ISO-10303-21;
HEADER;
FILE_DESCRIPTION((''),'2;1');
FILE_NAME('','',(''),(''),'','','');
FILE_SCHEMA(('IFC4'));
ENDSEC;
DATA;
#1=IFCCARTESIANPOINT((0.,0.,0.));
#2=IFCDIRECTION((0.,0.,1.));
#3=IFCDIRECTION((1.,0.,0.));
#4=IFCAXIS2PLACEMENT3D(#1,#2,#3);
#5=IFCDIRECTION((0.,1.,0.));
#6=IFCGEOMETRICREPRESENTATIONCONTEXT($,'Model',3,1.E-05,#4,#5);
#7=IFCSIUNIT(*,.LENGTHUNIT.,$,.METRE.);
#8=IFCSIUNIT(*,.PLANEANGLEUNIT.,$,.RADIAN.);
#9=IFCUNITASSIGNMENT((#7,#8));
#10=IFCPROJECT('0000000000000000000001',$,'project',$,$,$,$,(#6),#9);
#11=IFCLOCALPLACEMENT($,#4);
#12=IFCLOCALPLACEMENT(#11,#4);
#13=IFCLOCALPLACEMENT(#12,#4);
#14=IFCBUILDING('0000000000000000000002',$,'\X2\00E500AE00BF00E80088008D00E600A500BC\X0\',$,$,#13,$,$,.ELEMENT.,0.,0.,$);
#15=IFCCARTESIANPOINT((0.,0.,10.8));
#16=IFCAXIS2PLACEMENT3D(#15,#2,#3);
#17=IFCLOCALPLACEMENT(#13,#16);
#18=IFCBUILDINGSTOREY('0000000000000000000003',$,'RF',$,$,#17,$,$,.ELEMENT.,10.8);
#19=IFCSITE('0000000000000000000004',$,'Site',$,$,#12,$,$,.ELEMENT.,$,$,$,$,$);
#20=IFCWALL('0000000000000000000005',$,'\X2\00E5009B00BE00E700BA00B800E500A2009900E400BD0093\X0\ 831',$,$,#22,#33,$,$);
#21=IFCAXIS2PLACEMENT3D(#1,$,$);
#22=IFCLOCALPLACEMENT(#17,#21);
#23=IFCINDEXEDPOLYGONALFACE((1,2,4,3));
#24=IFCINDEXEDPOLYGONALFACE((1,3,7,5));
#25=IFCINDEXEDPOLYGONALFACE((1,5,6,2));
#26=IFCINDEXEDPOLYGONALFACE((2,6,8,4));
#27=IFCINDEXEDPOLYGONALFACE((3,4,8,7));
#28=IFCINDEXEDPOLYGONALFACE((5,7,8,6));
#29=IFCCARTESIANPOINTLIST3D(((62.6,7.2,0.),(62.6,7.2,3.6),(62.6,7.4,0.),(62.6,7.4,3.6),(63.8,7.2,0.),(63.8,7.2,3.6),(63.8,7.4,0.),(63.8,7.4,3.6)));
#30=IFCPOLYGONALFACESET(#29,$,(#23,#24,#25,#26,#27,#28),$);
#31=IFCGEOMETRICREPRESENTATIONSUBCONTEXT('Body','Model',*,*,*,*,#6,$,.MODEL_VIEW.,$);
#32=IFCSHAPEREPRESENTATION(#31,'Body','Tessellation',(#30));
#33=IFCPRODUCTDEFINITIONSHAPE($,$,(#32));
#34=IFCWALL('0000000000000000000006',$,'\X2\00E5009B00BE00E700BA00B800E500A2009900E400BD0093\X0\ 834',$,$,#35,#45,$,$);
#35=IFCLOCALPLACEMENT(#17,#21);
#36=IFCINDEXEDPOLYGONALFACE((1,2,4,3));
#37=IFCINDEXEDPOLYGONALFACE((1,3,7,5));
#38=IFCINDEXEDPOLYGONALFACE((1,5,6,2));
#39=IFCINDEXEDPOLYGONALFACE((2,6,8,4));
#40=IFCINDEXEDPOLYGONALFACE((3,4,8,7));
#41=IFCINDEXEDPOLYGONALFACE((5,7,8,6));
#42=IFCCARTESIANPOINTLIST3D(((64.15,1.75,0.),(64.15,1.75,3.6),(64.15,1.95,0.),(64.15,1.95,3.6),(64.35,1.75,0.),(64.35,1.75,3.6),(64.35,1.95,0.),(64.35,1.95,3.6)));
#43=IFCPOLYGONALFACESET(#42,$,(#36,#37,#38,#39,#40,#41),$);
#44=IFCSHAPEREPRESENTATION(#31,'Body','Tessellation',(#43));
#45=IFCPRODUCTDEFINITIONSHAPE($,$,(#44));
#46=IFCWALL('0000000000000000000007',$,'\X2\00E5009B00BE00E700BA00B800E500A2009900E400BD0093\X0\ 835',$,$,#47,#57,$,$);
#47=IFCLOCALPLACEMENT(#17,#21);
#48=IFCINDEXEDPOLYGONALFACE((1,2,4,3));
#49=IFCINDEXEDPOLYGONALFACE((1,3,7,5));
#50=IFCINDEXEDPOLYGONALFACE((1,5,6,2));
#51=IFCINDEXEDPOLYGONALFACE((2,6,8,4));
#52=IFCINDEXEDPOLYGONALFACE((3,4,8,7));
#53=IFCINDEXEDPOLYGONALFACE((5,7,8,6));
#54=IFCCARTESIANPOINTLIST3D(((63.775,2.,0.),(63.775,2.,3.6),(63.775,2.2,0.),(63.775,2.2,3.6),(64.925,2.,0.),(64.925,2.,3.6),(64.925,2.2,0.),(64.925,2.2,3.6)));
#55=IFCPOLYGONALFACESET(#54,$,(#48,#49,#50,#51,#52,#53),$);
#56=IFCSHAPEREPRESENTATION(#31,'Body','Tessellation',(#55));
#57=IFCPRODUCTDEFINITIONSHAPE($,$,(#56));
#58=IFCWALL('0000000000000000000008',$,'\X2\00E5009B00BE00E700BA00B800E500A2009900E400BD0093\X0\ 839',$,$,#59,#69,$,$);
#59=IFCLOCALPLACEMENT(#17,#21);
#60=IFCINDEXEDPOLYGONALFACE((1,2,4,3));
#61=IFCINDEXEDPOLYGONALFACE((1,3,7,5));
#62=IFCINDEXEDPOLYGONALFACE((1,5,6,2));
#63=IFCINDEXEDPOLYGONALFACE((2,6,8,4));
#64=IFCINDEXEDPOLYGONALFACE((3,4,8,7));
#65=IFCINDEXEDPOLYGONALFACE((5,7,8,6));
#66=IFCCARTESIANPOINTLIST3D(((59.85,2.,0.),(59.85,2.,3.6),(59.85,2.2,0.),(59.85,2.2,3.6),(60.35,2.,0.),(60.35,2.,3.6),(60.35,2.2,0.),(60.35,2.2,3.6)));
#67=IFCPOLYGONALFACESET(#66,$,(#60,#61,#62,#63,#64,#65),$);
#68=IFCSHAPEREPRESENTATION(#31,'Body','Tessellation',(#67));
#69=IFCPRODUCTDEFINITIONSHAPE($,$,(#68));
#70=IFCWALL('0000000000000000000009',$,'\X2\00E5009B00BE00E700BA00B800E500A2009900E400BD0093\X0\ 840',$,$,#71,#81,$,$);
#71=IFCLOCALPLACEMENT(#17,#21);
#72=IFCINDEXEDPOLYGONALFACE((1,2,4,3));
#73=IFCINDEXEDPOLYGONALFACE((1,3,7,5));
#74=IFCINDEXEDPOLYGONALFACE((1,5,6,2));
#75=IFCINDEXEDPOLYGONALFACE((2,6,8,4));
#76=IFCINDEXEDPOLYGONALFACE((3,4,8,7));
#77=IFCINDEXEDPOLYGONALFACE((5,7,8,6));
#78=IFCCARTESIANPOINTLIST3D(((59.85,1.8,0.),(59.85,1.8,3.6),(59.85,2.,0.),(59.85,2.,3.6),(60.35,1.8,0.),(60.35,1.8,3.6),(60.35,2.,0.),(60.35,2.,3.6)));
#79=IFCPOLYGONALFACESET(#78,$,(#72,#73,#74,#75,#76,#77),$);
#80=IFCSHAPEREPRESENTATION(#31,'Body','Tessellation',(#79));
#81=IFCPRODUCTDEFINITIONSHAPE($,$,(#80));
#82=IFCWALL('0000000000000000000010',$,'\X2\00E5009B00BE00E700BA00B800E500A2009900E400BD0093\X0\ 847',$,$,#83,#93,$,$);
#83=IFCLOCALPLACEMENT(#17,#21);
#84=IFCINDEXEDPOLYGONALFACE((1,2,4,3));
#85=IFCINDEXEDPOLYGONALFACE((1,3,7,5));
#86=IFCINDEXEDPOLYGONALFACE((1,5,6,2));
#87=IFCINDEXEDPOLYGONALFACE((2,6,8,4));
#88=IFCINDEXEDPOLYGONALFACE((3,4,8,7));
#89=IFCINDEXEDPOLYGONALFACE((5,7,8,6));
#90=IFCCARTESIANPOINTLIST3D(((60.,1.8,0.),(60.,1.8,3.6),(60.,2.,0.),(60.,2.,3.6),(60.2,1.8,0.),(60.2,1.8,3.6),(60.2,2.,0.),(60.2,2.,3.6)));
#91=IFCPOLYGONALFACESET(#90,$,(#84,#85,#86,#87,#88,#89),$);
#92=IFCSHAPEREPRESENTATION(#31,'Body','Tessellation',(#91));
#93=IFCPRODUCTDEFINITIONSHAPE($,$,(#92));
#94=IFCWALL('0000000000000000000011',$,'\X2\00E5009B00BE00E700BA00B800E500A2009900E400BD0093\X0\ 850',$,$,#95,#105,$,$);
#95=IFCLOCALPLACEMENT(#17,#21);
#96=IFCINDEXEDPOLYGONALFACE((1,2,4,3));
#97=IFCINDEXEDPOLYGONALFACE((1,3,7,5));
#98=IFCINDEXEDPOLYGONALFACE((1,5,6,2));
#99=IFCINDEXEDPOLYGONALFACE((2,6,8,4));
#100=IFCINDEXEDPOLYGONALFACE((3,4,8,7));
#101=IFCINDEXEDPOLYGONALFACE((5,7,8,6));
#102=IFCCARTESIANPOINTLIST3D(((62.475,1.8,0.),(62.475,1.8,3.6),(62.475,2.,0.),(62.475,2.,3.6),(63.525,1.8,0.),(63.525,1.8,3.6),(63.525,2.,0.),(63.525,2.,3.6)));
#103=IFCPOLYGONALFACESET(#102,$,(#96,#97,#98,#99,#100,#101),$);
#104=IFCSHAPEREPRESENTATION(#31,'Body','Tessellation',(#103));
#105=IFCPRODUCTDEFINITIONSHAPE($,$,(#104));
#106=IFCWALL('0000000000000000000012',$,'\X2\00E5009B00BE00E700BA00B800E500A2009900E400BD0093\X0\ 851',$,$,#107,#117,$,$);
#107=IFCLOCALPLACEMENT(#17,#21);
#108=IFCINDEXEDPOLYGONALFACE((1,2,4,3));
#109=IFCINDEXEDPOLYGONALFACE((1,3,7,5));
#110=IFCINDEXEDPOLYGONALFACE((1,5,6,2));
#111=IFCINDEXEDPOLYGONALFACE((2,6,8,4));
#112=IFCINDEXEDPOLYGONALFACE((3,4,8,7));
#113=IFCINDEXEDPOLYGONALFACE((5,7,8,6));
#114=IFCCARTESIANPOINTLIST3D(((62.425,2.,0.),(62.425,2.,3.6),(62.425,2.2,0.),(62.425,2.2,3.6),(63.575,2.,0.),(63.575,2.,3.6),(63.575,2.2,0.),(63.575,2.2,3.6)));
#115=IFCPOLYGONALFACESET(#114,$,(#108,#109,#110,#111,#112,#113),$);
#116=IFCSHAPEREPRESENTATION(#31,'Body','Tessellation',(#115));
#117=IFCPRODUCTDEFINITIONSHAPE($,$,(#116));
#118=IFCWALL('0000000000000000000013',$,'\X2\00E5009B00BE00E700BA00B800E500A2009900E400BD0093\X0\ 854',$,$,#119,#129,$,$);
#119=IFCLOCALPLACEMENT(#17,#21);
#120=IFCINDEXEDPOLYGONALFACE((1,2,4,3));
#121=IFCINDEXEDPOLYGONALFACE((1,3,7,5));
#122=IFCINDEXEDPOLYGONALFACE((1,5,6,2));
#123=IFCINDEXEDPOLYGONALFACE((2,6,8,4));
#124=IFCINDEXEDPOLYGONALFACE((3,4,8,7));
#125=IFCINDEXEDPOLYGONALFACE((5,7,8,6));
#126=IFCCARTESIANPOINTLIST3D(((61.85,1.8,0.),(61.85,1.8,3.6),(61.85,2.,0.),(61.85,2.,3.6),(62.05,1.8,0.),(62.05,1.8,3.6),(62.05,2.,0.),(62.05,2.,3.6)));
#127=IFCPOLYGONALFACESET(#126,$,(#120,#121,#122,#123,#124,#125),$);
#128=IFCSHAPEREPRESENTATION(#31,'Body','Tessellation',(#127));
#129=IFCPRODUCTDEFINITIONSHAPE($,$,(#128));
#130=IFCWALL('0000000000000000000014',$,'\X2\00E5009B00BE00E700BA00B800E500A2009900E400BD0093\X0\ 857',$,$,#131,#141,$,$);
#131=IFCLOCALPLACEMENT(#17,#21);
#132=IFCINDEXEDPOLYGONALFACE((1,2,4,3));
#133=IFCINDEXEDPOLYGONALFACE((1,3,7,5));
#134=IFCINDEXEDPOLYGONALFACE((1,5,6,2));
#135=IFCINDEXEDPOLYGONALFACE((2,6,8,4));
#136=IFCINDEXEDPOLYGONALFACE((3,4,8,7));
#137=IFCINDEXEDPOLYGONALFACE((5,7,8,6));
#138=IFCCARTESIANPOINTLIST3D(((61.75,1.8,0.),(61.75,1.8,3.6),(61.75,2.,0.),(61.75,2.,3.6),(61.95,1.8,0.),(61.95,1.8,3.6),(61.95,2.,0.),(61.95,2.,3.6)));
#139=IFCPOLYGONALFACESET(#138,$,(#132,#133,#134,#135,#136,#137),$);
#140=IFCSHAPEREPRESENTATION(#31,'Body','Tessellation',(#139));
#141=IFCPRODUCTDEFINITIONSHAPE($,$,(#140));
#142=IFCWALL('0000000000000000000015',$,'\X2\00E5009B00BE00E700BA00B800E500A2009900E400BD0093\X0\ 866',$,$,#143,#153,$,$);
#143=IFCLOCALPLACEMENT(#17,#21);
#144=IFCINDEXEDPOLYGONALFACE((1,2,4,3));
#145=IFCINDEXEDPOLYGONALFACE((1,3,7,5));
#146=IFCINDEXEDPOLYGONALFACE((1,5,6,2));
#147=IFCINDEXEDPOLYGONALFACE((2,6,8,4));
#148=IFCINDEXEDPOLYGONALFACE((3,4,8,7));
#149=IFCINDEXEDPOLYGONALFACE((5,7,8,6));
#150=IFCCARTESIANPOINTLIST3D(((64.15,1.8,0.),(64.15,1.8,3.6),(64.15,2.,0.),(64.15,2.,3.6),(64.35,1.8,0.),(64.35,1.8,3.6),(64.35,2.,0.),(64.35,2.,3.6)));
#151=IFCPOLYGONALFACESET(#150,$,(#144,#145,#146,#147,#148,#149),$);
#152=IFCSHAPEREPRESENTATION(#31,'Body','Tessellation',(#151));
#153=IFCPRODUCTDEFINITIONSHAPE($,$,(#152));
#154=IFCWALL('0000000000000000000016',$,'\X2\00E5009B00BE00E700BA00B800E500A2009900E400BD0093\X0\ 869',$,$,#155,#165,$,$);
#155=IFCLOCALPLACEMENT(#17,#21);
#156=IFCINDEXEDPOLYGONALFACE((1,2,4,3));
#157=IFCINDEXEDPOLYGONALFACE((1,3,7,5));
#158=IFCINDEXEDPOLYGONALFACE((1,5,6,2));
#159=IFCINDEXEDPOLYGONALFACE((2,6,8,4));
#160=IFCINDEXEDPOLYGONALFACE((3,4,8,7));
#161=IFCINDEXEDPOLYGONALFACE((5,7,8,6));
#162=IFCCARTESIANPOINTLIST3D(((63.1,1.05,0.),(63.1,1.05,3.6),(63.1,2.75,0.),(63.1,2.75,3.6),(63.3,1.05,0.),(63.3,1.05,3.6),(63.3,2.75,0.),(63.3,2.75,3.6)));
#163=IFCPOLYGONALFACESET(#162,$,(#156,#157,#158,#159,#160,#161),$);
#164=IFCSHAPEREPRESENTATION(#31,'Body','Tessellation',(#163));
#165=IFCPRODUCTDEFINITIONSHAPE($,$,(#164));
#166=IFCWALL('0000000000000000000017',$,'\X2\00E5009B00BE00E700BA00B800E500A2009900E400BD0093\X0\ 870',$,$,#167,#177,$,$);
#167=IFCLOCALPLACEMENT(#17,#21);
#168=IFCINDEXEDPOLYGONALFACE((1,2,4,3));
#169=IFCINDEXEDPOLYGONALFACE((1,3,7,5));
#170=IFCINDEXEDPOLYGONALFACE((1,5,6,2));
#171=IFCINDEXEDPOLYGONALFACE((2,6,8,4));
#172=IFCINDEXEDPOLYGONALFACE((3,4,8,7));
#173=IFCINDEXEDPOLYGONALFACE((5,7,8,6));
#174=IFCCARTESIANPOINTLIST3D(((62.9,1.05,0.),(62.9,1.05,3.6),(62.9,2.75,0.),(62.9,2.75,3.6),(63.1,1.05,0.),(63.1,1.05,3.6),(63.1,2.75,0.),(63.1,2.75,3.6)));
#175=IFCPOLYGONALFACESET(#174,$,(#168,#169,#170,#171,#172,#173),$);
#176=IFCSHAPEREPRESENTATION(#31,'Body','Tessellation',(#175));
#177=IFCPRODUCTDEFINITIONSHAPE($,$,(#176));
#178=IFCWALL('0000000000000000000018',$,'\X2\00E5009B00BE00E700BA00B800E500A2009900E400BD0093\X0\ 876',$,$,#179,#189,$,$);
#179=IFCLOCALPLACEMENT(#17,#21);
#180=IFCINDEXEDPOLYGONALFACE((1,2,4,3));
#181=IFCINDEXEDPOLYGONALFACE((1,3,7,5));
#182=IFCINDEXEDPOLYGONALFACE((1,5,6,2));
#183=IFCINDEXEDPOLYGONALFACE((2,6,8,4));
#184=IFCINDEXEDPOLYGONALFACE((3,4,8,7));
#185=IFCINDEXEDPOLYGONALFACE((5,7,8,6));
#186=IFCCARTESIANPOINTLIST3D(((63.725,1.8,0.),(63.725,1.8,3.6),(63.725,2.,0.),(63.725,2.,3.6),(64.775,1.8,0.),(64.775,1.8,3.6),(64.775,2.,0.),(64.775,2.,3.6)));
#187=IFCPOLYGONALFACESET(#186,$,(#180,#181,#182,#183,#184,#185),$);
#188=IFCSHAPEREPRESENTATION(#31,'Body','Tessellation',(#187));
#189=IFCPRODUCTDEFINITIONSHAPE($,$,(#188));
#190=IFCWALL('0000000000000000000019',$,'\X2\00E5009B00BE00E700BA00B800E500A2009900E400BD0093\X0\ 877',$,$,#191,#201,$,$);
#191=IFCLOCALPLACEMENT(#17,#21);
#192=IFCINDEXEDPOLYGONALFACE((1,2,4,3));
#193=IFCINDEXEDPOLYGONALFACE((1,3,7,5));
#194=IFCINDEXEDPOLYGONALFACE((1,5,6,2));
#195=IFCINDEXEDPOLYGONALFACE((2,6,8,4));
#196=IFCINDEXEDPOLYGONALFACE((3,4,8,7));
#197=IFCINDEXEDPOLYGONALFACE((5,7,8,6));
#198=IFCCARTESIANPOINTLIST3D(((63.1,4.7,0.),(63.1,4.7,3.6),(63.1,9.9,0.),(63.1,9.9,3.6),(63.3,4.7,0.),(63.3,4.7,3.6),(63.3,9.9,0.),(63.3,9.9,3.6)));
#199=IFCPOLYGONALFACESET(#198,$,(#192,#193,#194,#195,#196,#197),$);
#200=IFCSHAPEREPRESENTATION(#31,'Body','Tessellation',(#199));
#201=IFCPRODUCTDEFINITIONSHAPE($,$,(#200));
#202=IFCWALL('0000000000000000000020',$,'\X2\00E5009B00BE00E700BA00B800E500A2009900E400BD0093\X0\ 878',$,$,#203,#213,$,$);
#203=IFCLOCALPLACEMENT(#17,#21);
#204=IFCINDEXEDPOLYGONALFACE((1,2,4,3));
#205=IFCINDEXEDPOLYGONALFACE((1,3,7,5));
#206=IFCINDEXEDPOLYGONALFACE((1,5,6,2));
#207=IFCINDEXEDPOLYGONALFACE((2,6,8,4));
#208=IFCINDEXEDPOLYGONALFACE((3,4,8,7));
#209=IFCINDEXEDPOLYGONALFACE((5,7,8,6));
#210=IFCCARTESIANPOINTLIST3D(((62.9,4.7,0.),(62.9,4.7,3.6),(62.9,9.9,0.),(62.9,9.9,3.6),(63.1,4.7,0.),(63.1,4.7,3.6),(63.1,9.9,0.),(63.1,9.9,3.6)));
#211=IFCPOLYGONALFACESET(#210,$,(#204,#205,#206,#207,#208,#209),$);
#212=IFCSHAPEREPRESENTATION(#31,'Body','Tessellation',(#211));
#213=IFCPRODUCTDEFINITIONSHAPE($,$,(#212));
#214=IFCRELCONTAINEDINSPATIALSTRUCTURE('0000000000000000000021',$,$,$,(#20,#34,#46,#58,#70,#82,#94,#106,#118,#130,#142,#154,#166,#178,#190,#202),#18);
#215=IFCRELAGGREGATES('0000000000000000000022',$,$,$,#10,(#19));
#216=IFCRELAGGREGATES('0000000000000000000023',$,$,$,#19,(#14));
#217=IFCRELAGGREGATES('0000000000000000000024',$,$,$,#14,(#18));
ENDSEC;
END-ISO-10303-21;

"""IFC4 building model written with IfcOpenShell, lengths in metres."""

from ifc_helpers import new_model, si_unit, direction, frame, frame_2d, origin_with_axes, place, context, subcontext, project, spatial, rectangle, extrude, element, save


model = new_model("IFC4")

# Units and contexts
model_context = context("Model", 3, precision=1e-05, world=origin_with_axes(), true_north=direction((0.0, 1.0, 0.0)))
body_context = subcontext(model_context, "Body", "Model", "MODEL_VIEW")
ifc_project = project(units=[si_unit("LENGTHUNIT", "METRE"), si_unit("PLANEANGLEUNIT", "RADIAN")], contexts=[model_context])

# Site, building, storey
placement = place(None, origin_with_axes())
site_placement = place(placement, origin_with_axes())
site = spatial("IfcSite", under=ifc_project, at=site_placement, Name="Site", CompositionType="ELEMENT")
building_placement = place(site_placement, origin_with_axes())
building = spatial("IfcBuilding", under=site, at=building_placement, Name="å®¿è\u0088\u008dæ¥¼", CompositionType="ELEMENT", ElevationOfRefHeight=0.0, ElevationOfTerrain=0.0)
storey_placement = place(building_placement, frame((0.0, 0.0, 10.8), z_axis=(0.0, 0.0, 1.0), x_axis=(1.0, 0.0, 0.0)))
storey = spatial("IfcBuildingStorey", under=building, at=storey_placement, Name="RF", CompositionType="ELEMENT", Elevation=10.8)

# Walls
wall_1_placement = place(storey_placement, frame((63.2, 7.3, 0.0), z_axis=(0.0, 0.0, 1.0), x_axis=(1.0, 0.0, 0.0)))
element("IfcWall", 1, at=wall_1_placement, inside=storey, Name="å\u009b¾çº¸å¢\u0099ä½\u0093 831", context=body_context, shape_type="SweptSolid", body=[
    extrude(rectangle(XDim=1.2, YDim=0.2, at=frame_2d((0.0, 0.0), x_axis=(1.0, 0.0, 0.0))), frame((0.0, 0.0, 0.0), z_axis=(0.0, 0.0, 1.0)), (0.0, 0.0, 1.0), 3.6),
])
wall_2_placement = place(storey_placement, frame((64.25, 1.85, 0.0), z_axis=(0.0, 0.0, 1.0), x_axis=(1.0, 0.0, 0.0)))
element("IfcWall", 2, at=wall_2_placement, inside=storey, Name="å\u009b¾çº¸å¢\u0099ä½\u0093 834", context=body_context, shape_type="SweptSolid", body=[
    extrude(rectangle(XDim=0.2, YDim=0.2, at=frame_2d((0.0, 0.0), x_axis=(1.0, 0.0, 0.0))), frame((0.0, 0.0, 0.0), z_axis=(0.0, 0.0, 1.0)), (0.0, 0.0, 1.0), 3.6),
])
wall_3_placement = place(storey_placement, frame((64.35, 2.1, 0.0), z_axis=(0.0, 0.0, 1.0), x_axis=(-1.0, 0.0, 0.0)))
element("IfcWall", 3, at=wall_3_placement, inside=storey, Name="å\u009b¾çº¸å¢\u0099ä½\u0093 835", context=body_context, shape_type="SweptSolid", body=[
    extrude(rectangle(XDim=1.15, YDim=0.2, at=frame_2d((0.0, 0.0), x_axis=(1.0, 0.0, 0.0))), frame((0.0, 0.0, 0.0), z_axis=(0.0, 0.0, 1.0)), (0.0, 0.0, 1.0), 3.6),
])
for number, where, z_axis, x_axis, name in (
    (4, (60.1, 2.1, 0.0), (0.0, 0.0, 1.0), (-1.0, 0.0, 0.0), "å\u009b¾çº¸å¢\u0099ä½\u0093 839"),
    (5, (60.1, 1.9, 0.0), (0.0, 0.0, 1.0), (-1.0, 0.0, 0.0), "å\u009b¾çº¸å¢\u0099ä½\u0093 840"),
):
    element("IfcWall", number, at=place(storey_placement, frame(where, z_axis=z_axis, x_axis=x_axis)), inside=storey, Name=name, context=body_context, shape_type="SweptSolid", body=[
        extrude(rectangle(XDim=0.5, YDim=0.2, at=frame_2d((0.0, 0.0), x_axis=(1.0, 0.0, 0.0))), frame((0.0, 0.0, 0.0), z_axis=(0.0, 0.0, 1.0)), (0.0, 0.0, 1.0), 3.6),
    ])
wall_4_placement = place(storey_placement, frame((60.1, 1.9, 0.0), z_axis=(0.0, 0.0, 1.0), x_axis=(0.0, 1.0, 0.0)))
element("IfcWall", 6, at=wall_4_placement, inside=storey, Name="å\u009b¾çº¸å¢\u0099ä½\u0093 847", context=body_context, shape_type="SweptSolid", body=[
    extrude(rectangle(XDim=0.2, YDim=0.2, at=frame_2d((0.0, 0.0), x_axis=(1.0, 0.0, 0.0))), frame((0.0, 0.0, 0.0), z_axis=(0.0, 0.0, 1.0)), (0.0, 0.0, 1.0), 3.6),
])
wall_5_placement = place(storey_placement, frame((63.0, 1.9, 0.0), z_axis=(0.0, 0.0, 1.0), x_axis=(-1.0, 0.0, 0.0)))
element("IfcWall", 7, at=wall_5_placement, inside=storey, Name="å\u009b¾çº¸å¢\u0099ä½\u0093 850", context=body_context, shape_type="SweptSolid", body=[
    extrude(rectangle(XDim=1.05, YDim=0.2, at=frame_2d((0.0, 0.0), x_axis=(1.0, 0.0, 0.0))), frame((0.0, 0.0, 0.0), z_axis=(0.0, 0.0, 1.0)), (0.0, 0.0, 1.0), 3.6),
])
wall_6_placement = place(storey_placement, frame((63.0, 2.1, 0.0), z_axis=(0.0, 0.0, 1.0), x_axis=(-1.0, 0.0, 0.0)))
element("IfcWall", 8, at=wall_6_placement, inside=storey, Name="å\u009b¾çº¸å¢\u0099ä½\u0093 851", context=body_context, shape_type="SweptSolid", body=[
    extrude(rectangle(XDim=1.15, YDim=0.2, at=frame_2d((0.0, 0.0), x_axis=(1.0, 0.0, 0.0))), frame((0.0, 0.0, 0.0), z_axis=(0.0, 0.0, 1.0)), (0.0, 0.0, 1.0), 3.6),
])
for number, where, z_axis, x_axis, name in (
    (9, (61.95, 1.9, 0.0), (0.0, 0.0, 1.0), (0.0, -1.0, 0.0), "å\u009b¾çº¸å¢\u0099ä½\u0093 854"),
    (10, (61.85, 1.9, 0.0), (0.0, 0.0, 1.0), (0.0, 1.0, 0.0), "å\u009b¾çº¸å¢\u0099ä½\u0093 857"),
    (11, (64.25, 1.9, 0.0), (0.0, 0.0, 1.0), (0.0, -1.0, 0.0), "å\u009b¾çº¸å¢\u0099ä½\u0093 866"),
):
    element("IfcWall", number, at=place(storey_placement, frame(where, z_axis=z_axis, x_axis=x_axis)), inside=storey, Name=name, context=body_context, shape_type="SweptSolid", body=[
        extrude(rectangle(XDim=0.2, YDim=0.2, at=frame_2d((0.0, 0.0), x_axis=(1.0, 0.0, 0.0))), frame((0.0, 0.0, 0.0), z_axis=(0.0, 0.0, 1.0)), (0.0, 0.0, 1.0), 3.6),
    ])
for number, where, z_axis, x_axis, name in (
    (12, (63.2, 1.9, 0.0), (0.0, 0.0, 1.0), (0.0, -1.0, 0.0), "å\u009b¾çº¸å¢\u0099ä½\u0093 869"),
    (13, (63.0, 1.9, 0.0), (0.0, 0.0, 1.0), (0.0, -1.0, 0.0), "å\u009b¾çº¸å¢\u0099ä½\u0093 870"),
):
    element("IfcWall", number, at=place(storey_placement, frame(where, z_axis=z_axis, x_axis=x_axis)), inside=storey, Name=name, context=body_context, shape_type="SweptSolid", body=[
        extrude(rectangle(XDim=1.7, YDim=0.2, at=frame_2d((0.0, 0.0), x_axis=(1.0, 0.0, 0.0))), frame((0.0, 0.0, 0.0), z_axis=(0.0, 0.0, 1.0)), (0.0, 0.0, 1.0), 3.6),
    ])
wall_7_placement = place(storey_placement, frame((64.25, 1.9, 0.0), z_axis=(0.0, 0.0, 1.0), x_axis=(-1.0, 0.0, 0.0)))
element("IfcWall", 14, at=wall_7_placement, inside=storey, Name="å\u009b¾çº¸å¢\u0099ä½\u0093 876", context=body_context, shape_type="SweptSolid", body=[
    extrude(rectangle(XDim=1.05, YDim=0.2, at=frame_2d((0.0, 0.0), x_axis=(1.0, 0.0, 0.0))), frame((0.0, 0.0, 0.0), z_axis=(0.0, 0.0, 1.0)), (0.0, 0.0, 1.0), 3.6),
])
for number, where, z_axis, x_axis, name in (
    (15, (63.2, 7.3, 0.0), (0.0, 0.0, 1.0), (0.0, -1.0, 0.0), "å\u009b¾çº¸å¢\u0099ä½\u0093 877"),
    (16, (63.0, 7.3, 0.0), (0.0, 0.0, 1.0), (0.0, -1.0, 0.0), "å\u009b¾çº¸å¢\u0099ä½\u0093 878"),
):
    element("IfcWall", number, at=place(storey_placement, frame(where, z_axis=z_axis, x_axis=x_axis)), inside=storey, Name=name, context=body_context, shape_type="SweptSolid", body=[
        extrude(rectangle(XDim=5.2, YDim=0.2, at=frame_2d((0.0, 0.0), x_axis=(1.0, 0.0, 0.0))), frame((0.0, 0.0, 0.0), z_axis=(0.0, 0.0, 1.0)), (0.0, 0.0, 1.0), 3.6),
    ])

save(model, "model.ifc")
